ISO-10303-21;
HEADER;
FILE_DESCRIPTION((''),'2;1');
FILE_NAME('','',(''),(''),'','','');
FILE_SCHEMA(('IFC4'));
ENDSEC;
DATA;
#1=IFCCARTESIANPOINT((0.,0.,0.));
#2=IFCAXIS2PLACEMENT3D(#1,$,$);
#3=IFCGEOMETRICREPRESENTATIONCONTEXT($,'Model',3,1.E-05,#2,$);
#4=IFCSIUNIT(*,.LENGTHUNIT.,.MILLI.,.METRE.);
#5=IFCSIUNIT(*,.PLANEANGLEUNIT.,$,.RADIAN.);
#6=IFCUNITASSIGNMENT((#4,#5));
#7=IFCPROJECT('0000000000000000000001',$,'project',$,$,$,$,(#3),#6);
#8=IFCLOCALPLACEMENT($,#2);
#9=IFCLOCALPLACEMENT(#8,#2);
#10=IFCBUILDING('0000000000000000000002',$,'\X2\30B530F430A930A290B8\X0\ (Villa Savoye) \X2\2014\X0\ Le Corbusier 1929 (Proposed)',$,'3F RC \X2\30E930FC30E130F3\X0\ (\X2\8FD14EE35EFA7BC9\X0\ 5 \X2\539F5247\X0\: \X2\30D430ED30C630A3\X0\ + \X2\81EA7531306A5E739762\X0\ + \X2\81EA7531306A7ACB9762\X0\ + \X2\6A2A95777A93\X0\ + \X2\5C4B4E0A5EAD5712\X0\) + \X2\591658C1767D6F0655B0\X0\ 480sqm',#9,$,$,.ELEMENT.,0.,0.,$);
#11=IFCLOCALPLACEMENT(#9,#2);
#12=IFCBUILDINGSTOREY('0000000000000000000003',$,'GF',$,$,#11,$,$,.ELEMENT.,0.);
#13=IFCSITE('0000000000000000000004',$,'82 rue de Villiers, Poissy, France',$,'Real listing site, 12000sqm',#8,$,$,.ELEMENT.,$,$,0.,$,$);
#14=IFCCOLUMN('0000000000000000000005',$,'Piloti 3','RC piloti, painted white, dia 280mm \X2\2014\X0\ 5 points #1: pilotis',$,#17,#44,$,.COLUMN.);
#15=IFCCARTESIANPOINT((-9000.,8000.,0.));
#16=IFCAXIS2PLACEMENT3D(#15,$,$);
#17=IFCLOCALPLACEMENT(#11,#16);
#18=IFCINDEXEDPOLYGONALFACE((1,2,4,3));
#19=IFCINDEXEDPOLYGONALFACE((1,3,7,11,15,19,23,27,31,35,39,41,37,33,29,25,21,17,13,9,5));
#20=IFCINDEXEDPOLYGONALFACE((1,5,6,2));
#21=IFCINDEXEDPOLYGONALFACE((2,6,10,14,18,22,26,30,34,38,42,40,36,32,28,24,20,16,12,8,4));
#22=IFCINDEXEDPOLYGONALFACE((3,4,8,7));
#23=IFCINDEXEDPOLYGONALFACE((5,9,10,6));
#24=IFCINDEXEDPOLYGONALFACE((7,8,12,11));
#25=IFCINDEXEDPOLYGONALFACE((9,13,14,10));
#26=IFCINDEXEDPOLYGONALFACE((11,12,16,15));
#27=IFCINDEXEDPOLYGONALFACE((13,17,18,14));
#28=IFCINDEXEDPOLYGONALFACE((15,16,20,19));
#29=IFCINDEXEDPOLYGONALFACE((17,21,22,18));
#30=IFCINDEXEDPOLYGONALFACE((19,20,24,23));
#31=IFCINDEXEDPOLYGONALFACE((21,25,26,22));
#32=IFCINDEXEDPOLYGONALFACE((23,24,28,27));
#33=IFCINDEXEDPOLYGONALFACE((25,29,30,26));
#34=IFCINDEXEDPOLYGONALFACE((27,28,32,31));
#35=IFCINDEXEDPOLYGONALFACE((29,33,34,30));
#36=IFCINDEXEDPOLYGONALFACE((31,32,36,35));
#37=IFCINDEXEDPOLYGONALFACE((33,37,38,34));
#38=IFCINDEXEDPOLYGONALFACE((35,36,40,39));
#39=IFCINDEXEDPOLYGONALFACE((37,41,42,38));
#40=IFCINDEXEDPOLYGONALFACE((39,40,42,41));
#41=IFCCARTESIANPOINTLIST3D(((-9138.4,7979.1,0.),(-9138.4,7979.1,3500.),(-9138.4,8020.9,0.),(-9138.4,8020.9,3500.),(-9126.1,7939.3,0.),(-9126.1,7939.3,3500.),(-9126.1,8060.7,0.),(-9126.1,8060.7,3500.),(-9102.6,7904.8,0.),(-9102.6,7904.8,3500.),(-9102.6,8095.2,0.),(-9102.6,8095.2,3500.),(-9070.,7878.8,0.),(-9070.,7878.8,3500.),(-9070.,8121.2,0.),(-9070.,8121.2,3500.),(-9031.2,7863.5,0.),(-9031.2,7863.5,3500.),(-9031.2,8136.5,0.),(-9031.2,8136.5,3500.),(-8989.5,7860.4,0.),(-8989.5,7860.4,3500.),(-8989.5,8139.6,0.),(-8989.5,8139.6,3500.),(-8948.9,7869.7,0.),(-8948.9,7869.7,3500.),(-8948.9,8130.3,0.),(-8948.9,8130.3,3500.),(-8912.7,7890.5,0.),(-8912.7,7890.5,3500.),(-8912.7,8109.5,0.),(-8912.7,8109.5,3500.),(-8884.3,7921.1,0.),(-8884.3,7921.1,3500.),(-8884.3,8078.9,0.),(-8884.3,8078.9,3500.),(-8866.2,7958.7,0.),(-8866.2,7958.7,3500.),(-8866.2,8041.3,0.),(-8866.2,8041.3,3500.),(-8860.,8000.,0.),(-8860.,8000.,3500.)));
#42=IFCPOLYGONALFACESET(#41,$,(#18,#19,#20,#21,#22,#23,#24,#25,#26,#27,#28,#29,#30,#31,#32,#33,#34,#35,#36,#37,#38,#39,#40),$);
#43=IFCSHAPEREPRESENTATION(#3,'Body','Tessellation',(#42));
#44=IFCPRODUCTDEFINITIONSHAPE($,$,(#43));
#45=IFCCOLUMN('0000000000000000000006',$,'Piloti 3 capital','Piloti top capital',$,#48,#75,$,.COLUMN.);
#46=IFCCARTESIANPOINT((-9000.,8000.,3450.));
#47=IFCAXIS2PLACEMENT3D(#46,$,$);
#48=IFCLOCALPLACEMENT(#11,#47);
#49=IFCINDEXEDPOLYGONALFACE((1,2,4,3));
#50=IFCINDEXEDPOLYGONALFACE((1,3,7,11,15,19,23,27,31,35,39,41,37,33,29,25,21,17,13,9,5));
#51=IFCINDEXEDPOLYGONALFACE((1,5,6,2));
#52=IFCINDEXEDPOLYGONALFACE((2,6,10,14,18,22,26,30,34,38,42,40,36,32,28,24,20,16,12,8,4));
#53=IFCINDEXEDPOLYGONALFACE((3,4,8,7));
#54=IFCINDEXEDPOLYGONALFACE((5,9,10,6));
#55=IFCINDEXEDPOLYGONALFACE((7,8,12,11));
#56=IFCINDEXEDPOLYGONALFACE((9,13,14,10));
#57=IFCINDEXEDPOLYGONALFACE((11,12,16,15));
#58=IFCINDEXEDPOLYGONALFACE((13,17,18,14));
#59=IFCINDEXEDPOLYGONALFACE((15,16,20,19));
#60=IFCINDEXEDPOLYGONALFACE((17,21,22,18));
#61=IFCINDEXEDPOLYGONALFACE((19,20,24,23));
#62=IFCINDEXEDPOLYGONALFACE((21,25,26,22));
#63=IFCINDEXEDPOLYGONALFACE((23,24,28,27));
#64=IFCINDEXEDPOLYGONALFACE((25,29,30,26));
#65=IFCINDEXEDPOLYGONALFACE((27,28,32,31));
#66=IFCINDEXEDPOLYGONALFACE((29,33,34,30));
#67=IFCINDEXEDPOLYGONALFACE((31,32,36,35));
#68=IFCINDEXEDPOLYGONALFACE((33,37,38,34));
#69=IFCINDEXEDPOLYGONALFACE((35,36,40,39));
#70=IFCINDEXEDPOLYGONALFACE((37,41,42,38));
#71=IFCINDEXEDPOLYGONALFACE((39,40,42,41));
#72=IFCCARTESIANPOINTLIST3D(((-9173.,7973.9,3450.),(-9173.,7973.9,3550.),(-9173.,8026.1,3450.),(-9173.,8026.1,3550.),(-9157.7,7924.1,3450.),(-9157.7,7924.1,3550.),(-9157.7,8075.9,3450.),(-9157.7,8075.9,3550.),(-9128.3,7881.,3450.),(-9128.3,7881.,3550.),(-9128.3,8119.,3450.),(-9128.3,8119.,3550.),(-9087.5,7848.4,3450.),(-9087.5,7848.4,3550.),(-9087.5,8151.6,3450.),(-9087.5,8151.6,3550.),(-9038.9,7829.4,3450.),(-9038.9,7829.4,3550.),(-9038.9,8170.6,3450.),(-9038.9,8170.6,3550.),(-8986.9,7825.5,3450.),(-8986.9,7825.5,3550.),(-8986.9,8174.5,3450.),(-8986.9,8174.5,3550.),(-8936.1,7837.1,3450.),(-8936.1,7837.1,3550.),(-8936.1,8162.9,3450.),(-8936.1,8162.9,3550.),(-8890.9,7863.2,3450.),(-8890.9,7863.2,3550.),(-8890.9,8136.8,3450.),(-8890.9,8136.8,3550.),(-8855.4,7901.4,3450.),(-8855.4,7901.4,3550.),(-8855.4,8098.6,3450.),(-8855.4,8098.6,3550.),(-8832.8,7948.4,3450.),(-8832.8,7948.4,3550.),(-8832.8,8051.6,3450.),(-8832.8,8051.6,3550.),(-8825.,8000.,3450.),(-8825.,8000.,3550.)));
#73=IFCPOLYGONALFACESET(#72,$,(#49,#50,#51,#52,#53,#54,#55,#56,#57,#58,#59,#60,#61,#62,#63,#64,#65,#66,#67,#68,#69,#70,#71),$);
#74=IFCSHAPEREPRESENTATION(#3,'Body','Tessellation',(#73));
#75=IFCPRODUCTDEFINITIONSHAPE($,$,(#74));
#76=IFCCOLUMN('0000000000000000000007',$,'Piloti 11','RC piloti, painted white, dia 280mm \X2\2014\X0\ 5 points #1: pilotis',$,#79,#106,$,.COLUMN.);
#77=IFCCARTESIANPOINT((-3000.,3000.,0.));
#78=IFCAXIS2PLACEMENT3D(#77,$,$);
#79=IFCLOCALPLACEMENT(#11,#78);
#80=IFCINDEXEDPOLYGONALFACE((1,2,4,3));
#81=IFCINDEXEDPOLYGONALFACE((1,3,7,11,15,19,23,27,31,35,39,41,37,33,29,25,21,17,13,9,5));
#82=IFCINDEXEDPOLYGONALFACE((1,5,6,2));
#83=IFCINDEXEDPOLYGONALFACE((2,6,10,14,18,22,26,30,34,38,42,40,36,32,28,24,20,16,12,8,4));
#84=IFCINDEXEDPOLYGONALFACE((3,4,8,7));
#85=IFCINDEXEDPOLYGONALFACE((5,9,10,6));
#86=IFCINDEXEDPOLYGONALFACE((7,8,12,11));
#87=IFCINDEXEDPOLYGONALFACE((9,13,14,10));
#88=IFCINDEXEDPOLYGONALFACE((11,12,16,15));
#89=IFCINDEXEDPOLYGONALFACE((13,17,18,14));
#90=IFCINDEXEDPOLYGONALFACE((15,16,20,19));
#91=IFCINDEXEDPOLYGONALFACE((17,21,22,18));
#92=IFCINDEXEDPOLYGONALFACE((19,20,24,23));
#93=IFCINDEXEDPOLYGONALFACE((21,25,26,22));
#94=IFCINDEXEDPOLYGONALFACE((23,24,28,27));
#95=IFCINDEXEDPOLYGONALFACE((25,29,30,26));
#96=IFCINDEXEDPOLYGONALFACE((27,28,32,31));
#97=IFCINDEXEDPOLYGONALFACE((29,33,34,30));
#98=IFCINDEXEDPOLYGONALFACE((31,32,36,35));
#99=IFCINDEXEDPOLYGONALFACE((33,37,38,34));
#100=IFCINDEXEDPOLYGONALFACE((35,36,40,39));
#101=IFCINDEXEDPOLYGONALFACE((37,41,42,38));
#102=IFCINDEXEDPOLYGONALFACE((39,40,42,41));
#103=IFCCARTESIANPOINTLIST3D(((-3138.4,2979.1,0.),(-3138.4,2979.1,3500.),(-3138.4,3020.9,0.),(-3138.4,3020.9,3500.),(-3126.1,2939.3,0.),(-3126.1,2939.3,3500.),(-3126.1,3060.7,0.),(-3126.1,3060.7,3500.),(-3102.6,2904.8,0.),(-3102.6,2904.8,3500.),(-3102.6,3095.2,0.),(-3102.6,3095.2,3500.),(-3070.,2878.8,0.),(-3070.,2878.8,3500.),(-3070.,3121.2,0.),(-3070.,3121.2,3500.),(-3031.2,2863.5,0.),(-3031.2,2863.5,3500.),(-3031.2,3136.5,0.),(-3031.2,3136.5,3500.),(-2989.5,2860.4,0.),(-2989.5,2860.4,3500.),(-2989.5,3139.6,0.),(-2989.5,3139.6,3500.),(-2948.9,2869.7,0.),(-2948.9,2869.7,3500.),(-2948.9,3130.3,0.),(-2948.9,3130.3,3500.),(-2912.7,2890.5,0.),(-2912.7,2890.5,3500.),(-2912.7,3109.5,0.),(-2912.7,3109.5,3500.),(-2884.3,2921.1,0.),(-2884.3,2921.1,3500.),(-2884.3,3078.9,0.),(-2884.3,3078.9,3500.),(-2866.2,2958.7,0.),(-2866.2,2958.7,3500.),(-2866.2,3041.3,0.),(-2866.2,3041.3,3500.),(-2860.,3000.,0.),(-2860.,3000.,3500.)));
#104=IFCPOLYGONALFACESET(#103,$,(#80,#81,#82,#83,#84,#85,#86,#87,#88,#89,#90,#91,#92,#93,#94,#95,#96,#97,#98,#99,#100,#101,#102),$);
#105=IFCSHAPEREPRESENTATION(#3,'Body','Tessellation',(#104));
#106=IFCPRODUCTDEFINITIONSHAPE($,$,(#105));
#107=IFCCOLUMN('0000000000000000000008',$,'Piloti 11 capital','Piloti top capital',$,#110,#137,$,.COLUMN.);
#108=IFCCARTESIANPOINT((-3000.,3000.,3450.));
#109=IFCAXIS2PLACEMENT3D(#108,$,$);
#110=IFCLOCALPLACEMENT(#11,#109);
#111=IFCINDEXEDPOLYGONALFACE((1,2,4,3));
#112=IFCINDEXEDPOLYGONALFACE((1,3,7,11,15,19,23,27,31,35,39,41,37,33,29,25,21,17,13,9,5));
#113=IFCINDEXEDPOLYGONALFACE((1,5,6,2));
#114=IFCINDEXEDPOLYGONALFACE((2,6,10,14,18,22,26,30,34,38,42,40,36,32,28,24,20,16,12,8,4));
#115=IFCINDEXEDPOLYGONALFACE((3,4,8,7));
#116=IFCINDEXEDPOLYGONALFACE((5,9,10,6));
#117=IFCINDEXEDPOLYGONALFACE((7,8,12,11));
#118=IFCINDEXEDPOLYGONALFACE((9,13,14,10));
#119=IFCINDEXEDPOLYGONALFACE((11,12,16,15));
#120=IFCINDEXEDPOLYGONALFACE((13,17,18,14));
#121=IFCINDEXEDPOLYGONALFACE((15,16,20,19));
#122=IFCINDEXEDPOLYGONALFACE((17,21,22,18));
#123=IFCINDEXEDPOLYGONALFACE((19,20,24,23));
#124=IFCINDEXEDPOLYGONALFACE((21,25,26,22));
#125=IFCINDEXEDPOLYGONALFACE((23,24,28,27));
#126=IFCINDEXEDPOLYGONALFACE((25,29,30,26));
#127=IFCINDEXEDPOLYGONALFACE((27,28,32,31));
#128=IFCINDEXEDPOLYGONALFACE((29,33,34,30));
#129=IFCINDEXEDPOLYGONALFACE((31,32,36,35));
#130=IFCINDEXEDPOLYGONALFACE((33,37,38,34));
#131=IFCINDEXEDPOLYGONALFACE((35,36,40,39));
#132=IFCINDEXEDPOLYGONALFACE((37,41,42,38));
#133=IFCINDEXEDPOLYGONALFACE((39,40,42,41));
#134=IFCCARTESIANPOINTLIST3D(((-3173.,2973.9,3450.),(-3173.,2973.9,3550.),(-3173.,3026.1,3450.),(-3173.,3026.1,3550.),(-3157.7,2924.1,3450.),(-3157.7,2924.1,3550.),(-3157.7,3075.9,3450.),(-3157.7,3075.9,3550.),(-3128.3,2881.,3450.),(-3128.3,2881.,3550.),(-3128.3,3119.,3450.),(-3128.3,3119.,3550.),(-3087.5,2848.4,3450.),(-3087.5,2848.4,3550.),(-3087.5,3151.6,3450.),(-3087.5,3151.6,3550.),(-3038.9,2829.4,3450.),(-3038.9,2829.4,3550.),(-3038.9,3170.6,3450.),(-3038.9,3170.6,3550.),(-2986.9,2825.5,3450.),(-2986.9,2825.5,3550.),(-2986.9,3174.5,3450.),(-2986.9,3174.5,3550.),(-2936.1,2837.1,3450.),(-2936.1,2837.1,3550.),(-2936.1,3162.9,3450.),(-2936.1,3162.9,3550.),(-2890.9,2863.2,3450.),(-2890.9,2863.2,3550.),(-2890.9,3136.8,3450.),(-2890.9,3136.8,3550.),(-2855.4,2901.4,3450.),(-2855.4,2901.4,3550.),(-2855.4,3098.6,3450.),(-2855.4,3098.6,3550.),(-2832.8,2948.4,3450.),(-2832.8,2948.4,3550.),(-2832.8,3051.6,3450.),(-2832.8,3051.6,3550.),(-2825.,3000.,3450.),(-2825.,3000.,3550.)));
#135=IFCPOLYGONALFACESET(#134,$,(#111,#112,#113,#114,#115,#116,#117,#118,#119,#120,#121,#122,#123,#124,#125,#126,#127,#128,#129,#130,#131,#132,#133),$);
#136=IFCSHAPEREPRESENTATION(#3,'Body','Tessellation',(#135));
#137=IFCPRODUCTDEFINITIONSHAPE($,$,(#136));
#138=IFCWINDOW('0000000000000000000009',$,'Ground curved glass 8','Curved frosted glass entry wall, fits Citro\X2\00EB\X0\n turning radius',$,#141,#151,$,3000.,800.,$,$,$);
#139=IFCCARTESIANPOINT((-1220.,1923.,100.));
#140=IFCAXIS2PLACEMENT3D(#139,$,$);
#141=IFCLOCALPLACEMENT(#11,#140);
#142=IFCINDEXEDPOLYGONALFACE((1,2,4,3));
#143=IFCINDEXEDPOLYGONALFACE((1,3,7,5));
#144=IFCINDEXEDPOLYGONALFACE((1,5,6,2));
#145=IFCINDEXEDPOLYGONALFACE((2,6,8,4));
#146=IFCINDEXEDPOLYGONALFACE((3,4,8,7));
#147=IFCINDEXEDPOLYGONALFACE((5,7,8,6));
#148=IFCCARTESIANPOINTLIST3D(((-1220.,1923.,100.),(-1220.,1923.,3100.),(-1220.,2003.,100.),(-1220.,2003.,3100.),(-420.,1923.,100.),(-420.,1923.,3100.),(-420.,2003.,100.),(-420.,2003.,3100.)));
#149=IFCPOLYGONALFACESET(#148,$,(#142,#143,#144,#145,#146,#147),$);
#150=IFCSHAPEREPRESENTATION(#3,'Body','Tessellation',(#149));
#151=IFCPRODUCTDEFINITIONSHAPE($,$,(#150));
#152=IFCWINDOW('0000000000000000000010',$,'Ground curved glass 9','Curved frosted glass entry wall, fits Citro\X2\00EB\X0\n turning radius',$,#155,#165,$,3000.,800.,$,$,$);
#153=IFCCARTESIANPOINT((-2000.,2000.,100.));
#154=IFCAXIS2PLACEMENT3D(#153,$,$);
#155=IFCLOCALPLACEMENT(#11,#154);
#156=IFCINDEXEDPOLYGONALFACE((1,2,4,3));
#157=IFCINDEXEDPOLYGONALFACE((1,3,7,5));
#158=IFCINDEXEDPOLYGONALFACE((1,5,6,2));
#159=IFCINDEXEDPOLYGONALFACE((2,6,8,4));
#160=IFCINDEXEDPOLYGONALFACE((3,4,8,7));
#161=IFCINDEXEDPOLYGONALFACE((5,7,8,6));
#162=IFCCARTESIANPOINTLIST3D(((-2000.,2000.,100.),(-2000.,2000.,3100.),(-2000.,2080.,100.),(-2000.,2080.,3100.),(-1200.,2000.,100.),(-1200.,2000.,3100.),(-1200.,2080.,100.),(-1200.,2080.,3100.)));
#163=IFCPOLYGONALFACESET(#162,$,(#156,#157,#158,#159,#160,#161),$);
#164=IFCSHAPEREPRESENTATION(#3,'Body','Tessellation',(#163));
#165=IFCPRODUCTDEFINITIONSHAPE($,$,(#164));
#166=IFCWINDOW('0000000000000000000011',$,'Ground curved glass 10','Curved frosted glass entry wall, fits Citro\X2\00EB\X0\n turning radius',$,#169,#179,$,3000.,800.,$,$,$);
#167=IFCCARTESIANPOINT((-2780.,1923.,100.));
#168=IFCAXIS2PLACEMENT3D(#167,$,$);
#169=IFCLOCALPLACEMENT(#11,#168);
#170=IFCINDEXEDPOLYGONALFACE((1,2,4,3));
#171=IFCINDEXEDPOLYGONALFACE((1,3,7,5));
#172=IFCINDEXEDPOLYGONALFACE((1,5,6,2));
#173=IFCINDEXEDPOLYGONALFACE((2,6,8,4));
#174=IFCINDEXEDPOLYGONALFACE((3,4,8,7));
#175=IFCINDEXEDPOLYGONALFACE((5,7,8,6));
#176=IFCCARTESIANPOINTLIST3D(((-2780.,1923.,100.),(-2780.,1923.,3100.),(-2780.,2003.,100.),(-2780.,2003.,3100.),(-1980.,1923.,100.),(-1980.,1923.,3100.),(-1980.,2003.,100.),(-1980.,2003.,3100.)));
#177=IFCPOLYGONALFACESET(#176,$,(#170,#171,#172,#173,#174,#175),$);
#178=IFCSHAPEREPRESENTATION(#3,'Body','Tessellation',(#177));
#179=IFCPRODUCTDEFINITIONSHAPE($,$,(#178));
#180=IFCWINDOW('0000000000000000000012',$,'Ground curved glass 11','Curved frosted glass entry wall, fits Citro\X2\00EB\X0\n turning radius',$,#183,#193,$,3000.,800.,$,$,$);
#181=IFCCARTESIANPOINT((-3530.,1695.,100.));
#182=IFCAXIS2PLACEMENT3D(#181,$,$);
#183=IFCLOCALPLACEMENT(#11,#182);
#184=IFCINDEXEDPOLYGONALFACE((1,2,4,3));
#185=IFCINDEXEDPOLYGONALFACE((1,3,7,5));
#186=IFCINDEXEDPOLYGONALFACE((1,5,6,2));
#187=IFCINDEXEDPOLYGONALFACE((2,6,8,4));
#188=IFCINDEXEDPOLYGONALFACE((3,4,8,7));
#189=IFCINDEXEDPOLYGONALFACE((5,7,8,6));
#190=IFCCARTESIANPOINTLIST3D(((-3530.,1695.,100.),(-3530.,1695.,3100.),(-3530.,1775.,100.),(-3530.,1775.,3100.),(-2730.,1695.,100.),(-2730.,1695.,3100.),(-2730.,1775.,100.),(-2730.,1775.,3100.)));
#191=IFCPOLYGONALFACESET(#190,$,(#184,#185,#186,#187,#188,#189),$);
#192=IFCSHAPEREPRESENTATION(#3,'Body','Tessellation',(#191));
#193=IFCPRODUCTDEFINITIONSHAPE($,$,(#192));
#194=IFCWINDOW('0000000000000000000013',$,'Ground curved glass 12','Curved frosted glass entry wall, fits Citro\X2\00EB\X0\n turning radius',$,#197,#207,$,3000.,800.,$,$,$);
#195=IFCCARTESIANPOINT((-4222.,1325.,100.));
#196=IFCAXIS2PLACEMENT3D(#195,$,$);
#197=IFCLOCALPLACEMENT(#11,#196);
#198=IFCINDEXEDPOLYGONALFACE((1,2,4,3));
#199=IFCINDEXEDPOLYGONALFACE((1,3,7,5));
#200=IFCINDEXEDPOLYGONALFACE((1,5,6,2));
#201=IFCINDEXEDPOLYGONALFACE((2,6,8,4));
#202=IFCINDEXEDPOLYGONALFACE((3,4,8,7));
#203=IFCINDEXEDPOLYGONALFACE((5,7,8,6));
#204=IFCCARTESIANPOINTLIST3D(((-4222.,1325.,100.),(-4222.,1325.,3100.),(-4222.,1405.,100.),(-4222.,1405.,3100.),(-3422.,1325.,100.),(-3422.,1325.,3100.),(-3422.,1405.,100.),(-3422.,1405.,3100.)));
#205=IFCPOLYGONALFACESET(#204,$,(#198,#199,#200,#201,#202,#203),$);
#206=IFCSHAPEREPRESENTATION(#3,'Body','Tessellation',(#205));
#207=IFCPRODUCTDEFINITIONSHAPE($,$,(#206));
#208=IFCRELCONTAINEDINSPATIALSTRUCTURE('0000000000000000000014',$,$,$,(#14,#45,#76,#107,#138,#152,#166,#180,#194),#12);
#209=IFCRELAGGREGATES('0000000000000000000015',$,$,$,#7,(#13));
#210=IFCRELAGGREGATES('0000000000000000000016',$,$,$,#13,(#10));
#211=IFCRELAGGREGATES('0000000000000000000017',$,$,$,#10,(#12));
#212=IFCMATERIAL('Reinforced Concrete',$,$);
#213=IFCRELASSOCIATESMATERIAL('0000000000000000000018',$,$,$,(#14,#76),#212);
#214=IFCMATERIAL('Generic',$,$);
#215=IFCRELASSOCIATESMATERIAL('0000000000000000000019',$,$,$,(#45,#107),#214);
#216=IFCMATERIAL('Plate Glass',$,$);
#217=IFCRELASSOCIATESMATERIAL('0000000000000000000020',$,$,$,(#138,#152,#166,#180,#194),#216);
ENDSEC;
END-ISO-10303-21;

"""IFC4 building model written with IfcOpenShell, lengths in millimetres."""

from ifc_helpers import new_model, si_unit, frame, frame_2d, origin, origin_2d, place, context, project, spatial, rectangle, circle, extrude, material, element, save


model = new_model("IFC4")

# Units and contexts
model_context = context("Model", 3, precision=1e-05, world=origin())
ifc_project = project(units=[si_unit("LENGTHUNIT", "METRE", prefix="MILLI"), si_unit("PLANEANGLEUNIT", "RADIAN")], contexts=[model_context])

# Site, building, storey
site_placement = place(None, origin())
site = spatial("IfcSite", under=ifc_project, at=site_placement, Name="82 rue de Villiers, Poissy, France", ObjectType="Real listing site, 12000sqm", CompositionType="ELEMENT", RefElevation=0.0)
building_placement = place(site_placement, origin())
building = spatial("IfcBuilding", under=site, at=building_placement, Name="サヴォア邸 (Villa Savoye) — Le Corbusier 1929 (Proposed)", ObjectType="3F RC ラーメン (近代建築 5 原則: ピロティ + 自由な平面 + 自由な立面 + 横長窓 + 屋上庭園) + 外壁白漆喰 480sqm", CompositionType="ELEMENT", ElevationOfRefHeight=0.0, ElevationOfTerrain=0.0)
storey_placement = place(building_placement, origin())
storey = spatial("IfcBuildingStorey", under=building, at=storey_placement, Name="GF", CompositionType="ELEMENT", Elevation=0.0)

# Columns
ifc_material_1 = material(Name="Reinforced Concrete")
column_1_placement = place(storey_placement, frame((-9000.0, 8000.0, 0.0)))
element("IfcColumn", 1, at=column_1_placement, inside=storey, material=ifc_material_1, Name="Piloti 3", Description="RC piloti, painted white, dia 280mm — 5 points #1: pilotis", PredefinedType="COLUMN", context=model_context, shape_type="SweptSolid", body=[
    extrude(circle(Radius=140.0, at=origin_2d()), frame((-9000.0, 8000.0, 0.0)), (0.0, 0.0, 1.0), 3500.0),
])
ifc_material_2 = material(Name="Generic")
column_2_placement = place(storey_placement, frame((-9000.0, 8000.0, 3450.0)))
element("IfcColumn", 2, at=column_2_placement, inside=storey, material=ifc_material_2, Name="Piloti 3 capital", Description="Piloti top capital", PredefinedType="COLUMN", context=model_context, shape_type="SweptSolid", body=[
    extrude(circle(Radius=175.0, at=origin_2d()), frame((-9000.0, 8000.0, 3450.0)), (0.0, 0.0, 1.0), 100.0),
])
column_3_placement = place(storey_placement, frame((-3000.0, 3000.0, 0.0)))
element("IfcColumn", 3, at=column_3_placement, inside=storey, material=ifc_material_1, Name="Piloti 11", Description="RC piloti, painted white, dia 280mm — 5 points #1: pilotis", PredefinedType="COLUMN", context=model_context, shape_type="SweptSolid", body=[
    extrude(circle(Radius=140.0, at=origin_2d()), frame((-3000.0, 3000.0, 0.0)), (0.0, 0.0, 1.0), 3500.0),
])
column_4_placement = place(storey_placement, frame((-3000.0, 3000.0, 3450.0)))
element("IfcColumn", 4, at=column_4_placement, inside=storey, material=ifc_material_2, Name="Piloti 11 capital", Description="Piloti top capital", PredefinedType="COLUMN", context=model_context, shape_type="SweptSolid", body=[
    extrude(circle(Radius=175.0, at=origin_2d()), frame((-3000.0, 3000.0, 3450.0)), (0.0, 0.0, 1.0), 100.0),
])

# Windows
ifc_material_3 = material(Name="Plate Glass")
window_1_placement = place(storey_placement, frame((-1220.0, 1923.0, 100.0)))
element("IfcWindow", 5, at=window_1_placement, inside=storey, material=ifc_material_3, Name="Ground curved glass 8", Description="Curved frosted glass entry wall, fits Citroën turning radius", OverallHeight=3000.0, OverallWidth=800.0, context=model_context, shape_type="SweptSolid", body=[
    extrude(rectangle(XDim=800.0, YDim=80.0, at=frame_2d((400.0, 40.0))), frame((-1220.0, 1923.0, 100.0)), (0.0, 0.0, 1.0), 3000.0),
])
window_2_placement = place(storey_placement, frame((-2000.0, 2000.0, 100.0)))
element("IfcWindow", 6, at=window_2_placement, inside=storey, material=ifc_material_3, Name="Ground curved glass 9", Description="Curved frosted glass entry wall, fits Citroën turning radius", OverallHeight=3000.0, OverallWidth=800.0, context=model_context, shape_type="SweptSolid", body=[
    extrude(rectangle(XDim=800.0, YDim=80.0, at=frame_2d((400.0, 40.0))), frame((-2000.0, 2000.0, 100.0)), (0.0, 0.0, 1.0), 3000.0),
])
window_3_placement = place(storey_placement, frame((-2780.0, 1923.0, 100.0)))
element("IfcWindow", 7, at=window_3_placement, inside=storey, material=ifc_material_3, Name="Ground curved glass 10", Description="Curved frosted glass entry wall, fits Citroën turning radius", OverallHeight=3000.0, OverallWidth=800.0, context=model_context, shape_type="SweptSolid", body=[
    extrude(rectangle(XDim=800.0, YDim=80.0, at=frame_2d((400.0, 40.0))), frame((-2780.0, 1923.0, 100.0)), (0.0, 0.0, 1.0), 3000.0),
])
window_4_placement = place(storey_placement, frame((-3530.0, 1695.0, 100.0)))
element("IfcWindow", 8, at=window_4_placement, inside=storey, material=ifc_material_3, Name="Ground curved glass 11", Description="Curved frosted glass entry wall, fits Citroën turning radius", OverallHeight=3000.0, OverallWidth=800.0, context=model_context, shape_type="SweptSolid", body=[
    extrude(rectangle(XDim=800.0, YDim=80.0, at=frame_2d((400.0, 40.0))), frame((-3530.0, 1695.0, 100.0)), (0.0, 0.0, 1.0), 3000.0),
])
window_5_placement = place(storey_placement, frame((-4222.0, 1325.0, 100.0)))
element("IfcWindow", 9, at=window_5_placement, inside=storey, material=ifc_material_3, Name="Ground curved glass 12", Description="Curved frosted glass entry wall, fits Citroën turning radius", OverallHeight=3000.0, OverallWidth=800.0, context=model_context, shape_type="SweptSolid", body=[
    extrude(rectangle(XDim=800.0, YDim=80.0, at=frame_2d((400.0, 40.0))), frame((-4222.0, 1325.0, 100.0)), (0.0, 0.0, 1.0), 3000.0),
])

save(model, "model.ifc")
